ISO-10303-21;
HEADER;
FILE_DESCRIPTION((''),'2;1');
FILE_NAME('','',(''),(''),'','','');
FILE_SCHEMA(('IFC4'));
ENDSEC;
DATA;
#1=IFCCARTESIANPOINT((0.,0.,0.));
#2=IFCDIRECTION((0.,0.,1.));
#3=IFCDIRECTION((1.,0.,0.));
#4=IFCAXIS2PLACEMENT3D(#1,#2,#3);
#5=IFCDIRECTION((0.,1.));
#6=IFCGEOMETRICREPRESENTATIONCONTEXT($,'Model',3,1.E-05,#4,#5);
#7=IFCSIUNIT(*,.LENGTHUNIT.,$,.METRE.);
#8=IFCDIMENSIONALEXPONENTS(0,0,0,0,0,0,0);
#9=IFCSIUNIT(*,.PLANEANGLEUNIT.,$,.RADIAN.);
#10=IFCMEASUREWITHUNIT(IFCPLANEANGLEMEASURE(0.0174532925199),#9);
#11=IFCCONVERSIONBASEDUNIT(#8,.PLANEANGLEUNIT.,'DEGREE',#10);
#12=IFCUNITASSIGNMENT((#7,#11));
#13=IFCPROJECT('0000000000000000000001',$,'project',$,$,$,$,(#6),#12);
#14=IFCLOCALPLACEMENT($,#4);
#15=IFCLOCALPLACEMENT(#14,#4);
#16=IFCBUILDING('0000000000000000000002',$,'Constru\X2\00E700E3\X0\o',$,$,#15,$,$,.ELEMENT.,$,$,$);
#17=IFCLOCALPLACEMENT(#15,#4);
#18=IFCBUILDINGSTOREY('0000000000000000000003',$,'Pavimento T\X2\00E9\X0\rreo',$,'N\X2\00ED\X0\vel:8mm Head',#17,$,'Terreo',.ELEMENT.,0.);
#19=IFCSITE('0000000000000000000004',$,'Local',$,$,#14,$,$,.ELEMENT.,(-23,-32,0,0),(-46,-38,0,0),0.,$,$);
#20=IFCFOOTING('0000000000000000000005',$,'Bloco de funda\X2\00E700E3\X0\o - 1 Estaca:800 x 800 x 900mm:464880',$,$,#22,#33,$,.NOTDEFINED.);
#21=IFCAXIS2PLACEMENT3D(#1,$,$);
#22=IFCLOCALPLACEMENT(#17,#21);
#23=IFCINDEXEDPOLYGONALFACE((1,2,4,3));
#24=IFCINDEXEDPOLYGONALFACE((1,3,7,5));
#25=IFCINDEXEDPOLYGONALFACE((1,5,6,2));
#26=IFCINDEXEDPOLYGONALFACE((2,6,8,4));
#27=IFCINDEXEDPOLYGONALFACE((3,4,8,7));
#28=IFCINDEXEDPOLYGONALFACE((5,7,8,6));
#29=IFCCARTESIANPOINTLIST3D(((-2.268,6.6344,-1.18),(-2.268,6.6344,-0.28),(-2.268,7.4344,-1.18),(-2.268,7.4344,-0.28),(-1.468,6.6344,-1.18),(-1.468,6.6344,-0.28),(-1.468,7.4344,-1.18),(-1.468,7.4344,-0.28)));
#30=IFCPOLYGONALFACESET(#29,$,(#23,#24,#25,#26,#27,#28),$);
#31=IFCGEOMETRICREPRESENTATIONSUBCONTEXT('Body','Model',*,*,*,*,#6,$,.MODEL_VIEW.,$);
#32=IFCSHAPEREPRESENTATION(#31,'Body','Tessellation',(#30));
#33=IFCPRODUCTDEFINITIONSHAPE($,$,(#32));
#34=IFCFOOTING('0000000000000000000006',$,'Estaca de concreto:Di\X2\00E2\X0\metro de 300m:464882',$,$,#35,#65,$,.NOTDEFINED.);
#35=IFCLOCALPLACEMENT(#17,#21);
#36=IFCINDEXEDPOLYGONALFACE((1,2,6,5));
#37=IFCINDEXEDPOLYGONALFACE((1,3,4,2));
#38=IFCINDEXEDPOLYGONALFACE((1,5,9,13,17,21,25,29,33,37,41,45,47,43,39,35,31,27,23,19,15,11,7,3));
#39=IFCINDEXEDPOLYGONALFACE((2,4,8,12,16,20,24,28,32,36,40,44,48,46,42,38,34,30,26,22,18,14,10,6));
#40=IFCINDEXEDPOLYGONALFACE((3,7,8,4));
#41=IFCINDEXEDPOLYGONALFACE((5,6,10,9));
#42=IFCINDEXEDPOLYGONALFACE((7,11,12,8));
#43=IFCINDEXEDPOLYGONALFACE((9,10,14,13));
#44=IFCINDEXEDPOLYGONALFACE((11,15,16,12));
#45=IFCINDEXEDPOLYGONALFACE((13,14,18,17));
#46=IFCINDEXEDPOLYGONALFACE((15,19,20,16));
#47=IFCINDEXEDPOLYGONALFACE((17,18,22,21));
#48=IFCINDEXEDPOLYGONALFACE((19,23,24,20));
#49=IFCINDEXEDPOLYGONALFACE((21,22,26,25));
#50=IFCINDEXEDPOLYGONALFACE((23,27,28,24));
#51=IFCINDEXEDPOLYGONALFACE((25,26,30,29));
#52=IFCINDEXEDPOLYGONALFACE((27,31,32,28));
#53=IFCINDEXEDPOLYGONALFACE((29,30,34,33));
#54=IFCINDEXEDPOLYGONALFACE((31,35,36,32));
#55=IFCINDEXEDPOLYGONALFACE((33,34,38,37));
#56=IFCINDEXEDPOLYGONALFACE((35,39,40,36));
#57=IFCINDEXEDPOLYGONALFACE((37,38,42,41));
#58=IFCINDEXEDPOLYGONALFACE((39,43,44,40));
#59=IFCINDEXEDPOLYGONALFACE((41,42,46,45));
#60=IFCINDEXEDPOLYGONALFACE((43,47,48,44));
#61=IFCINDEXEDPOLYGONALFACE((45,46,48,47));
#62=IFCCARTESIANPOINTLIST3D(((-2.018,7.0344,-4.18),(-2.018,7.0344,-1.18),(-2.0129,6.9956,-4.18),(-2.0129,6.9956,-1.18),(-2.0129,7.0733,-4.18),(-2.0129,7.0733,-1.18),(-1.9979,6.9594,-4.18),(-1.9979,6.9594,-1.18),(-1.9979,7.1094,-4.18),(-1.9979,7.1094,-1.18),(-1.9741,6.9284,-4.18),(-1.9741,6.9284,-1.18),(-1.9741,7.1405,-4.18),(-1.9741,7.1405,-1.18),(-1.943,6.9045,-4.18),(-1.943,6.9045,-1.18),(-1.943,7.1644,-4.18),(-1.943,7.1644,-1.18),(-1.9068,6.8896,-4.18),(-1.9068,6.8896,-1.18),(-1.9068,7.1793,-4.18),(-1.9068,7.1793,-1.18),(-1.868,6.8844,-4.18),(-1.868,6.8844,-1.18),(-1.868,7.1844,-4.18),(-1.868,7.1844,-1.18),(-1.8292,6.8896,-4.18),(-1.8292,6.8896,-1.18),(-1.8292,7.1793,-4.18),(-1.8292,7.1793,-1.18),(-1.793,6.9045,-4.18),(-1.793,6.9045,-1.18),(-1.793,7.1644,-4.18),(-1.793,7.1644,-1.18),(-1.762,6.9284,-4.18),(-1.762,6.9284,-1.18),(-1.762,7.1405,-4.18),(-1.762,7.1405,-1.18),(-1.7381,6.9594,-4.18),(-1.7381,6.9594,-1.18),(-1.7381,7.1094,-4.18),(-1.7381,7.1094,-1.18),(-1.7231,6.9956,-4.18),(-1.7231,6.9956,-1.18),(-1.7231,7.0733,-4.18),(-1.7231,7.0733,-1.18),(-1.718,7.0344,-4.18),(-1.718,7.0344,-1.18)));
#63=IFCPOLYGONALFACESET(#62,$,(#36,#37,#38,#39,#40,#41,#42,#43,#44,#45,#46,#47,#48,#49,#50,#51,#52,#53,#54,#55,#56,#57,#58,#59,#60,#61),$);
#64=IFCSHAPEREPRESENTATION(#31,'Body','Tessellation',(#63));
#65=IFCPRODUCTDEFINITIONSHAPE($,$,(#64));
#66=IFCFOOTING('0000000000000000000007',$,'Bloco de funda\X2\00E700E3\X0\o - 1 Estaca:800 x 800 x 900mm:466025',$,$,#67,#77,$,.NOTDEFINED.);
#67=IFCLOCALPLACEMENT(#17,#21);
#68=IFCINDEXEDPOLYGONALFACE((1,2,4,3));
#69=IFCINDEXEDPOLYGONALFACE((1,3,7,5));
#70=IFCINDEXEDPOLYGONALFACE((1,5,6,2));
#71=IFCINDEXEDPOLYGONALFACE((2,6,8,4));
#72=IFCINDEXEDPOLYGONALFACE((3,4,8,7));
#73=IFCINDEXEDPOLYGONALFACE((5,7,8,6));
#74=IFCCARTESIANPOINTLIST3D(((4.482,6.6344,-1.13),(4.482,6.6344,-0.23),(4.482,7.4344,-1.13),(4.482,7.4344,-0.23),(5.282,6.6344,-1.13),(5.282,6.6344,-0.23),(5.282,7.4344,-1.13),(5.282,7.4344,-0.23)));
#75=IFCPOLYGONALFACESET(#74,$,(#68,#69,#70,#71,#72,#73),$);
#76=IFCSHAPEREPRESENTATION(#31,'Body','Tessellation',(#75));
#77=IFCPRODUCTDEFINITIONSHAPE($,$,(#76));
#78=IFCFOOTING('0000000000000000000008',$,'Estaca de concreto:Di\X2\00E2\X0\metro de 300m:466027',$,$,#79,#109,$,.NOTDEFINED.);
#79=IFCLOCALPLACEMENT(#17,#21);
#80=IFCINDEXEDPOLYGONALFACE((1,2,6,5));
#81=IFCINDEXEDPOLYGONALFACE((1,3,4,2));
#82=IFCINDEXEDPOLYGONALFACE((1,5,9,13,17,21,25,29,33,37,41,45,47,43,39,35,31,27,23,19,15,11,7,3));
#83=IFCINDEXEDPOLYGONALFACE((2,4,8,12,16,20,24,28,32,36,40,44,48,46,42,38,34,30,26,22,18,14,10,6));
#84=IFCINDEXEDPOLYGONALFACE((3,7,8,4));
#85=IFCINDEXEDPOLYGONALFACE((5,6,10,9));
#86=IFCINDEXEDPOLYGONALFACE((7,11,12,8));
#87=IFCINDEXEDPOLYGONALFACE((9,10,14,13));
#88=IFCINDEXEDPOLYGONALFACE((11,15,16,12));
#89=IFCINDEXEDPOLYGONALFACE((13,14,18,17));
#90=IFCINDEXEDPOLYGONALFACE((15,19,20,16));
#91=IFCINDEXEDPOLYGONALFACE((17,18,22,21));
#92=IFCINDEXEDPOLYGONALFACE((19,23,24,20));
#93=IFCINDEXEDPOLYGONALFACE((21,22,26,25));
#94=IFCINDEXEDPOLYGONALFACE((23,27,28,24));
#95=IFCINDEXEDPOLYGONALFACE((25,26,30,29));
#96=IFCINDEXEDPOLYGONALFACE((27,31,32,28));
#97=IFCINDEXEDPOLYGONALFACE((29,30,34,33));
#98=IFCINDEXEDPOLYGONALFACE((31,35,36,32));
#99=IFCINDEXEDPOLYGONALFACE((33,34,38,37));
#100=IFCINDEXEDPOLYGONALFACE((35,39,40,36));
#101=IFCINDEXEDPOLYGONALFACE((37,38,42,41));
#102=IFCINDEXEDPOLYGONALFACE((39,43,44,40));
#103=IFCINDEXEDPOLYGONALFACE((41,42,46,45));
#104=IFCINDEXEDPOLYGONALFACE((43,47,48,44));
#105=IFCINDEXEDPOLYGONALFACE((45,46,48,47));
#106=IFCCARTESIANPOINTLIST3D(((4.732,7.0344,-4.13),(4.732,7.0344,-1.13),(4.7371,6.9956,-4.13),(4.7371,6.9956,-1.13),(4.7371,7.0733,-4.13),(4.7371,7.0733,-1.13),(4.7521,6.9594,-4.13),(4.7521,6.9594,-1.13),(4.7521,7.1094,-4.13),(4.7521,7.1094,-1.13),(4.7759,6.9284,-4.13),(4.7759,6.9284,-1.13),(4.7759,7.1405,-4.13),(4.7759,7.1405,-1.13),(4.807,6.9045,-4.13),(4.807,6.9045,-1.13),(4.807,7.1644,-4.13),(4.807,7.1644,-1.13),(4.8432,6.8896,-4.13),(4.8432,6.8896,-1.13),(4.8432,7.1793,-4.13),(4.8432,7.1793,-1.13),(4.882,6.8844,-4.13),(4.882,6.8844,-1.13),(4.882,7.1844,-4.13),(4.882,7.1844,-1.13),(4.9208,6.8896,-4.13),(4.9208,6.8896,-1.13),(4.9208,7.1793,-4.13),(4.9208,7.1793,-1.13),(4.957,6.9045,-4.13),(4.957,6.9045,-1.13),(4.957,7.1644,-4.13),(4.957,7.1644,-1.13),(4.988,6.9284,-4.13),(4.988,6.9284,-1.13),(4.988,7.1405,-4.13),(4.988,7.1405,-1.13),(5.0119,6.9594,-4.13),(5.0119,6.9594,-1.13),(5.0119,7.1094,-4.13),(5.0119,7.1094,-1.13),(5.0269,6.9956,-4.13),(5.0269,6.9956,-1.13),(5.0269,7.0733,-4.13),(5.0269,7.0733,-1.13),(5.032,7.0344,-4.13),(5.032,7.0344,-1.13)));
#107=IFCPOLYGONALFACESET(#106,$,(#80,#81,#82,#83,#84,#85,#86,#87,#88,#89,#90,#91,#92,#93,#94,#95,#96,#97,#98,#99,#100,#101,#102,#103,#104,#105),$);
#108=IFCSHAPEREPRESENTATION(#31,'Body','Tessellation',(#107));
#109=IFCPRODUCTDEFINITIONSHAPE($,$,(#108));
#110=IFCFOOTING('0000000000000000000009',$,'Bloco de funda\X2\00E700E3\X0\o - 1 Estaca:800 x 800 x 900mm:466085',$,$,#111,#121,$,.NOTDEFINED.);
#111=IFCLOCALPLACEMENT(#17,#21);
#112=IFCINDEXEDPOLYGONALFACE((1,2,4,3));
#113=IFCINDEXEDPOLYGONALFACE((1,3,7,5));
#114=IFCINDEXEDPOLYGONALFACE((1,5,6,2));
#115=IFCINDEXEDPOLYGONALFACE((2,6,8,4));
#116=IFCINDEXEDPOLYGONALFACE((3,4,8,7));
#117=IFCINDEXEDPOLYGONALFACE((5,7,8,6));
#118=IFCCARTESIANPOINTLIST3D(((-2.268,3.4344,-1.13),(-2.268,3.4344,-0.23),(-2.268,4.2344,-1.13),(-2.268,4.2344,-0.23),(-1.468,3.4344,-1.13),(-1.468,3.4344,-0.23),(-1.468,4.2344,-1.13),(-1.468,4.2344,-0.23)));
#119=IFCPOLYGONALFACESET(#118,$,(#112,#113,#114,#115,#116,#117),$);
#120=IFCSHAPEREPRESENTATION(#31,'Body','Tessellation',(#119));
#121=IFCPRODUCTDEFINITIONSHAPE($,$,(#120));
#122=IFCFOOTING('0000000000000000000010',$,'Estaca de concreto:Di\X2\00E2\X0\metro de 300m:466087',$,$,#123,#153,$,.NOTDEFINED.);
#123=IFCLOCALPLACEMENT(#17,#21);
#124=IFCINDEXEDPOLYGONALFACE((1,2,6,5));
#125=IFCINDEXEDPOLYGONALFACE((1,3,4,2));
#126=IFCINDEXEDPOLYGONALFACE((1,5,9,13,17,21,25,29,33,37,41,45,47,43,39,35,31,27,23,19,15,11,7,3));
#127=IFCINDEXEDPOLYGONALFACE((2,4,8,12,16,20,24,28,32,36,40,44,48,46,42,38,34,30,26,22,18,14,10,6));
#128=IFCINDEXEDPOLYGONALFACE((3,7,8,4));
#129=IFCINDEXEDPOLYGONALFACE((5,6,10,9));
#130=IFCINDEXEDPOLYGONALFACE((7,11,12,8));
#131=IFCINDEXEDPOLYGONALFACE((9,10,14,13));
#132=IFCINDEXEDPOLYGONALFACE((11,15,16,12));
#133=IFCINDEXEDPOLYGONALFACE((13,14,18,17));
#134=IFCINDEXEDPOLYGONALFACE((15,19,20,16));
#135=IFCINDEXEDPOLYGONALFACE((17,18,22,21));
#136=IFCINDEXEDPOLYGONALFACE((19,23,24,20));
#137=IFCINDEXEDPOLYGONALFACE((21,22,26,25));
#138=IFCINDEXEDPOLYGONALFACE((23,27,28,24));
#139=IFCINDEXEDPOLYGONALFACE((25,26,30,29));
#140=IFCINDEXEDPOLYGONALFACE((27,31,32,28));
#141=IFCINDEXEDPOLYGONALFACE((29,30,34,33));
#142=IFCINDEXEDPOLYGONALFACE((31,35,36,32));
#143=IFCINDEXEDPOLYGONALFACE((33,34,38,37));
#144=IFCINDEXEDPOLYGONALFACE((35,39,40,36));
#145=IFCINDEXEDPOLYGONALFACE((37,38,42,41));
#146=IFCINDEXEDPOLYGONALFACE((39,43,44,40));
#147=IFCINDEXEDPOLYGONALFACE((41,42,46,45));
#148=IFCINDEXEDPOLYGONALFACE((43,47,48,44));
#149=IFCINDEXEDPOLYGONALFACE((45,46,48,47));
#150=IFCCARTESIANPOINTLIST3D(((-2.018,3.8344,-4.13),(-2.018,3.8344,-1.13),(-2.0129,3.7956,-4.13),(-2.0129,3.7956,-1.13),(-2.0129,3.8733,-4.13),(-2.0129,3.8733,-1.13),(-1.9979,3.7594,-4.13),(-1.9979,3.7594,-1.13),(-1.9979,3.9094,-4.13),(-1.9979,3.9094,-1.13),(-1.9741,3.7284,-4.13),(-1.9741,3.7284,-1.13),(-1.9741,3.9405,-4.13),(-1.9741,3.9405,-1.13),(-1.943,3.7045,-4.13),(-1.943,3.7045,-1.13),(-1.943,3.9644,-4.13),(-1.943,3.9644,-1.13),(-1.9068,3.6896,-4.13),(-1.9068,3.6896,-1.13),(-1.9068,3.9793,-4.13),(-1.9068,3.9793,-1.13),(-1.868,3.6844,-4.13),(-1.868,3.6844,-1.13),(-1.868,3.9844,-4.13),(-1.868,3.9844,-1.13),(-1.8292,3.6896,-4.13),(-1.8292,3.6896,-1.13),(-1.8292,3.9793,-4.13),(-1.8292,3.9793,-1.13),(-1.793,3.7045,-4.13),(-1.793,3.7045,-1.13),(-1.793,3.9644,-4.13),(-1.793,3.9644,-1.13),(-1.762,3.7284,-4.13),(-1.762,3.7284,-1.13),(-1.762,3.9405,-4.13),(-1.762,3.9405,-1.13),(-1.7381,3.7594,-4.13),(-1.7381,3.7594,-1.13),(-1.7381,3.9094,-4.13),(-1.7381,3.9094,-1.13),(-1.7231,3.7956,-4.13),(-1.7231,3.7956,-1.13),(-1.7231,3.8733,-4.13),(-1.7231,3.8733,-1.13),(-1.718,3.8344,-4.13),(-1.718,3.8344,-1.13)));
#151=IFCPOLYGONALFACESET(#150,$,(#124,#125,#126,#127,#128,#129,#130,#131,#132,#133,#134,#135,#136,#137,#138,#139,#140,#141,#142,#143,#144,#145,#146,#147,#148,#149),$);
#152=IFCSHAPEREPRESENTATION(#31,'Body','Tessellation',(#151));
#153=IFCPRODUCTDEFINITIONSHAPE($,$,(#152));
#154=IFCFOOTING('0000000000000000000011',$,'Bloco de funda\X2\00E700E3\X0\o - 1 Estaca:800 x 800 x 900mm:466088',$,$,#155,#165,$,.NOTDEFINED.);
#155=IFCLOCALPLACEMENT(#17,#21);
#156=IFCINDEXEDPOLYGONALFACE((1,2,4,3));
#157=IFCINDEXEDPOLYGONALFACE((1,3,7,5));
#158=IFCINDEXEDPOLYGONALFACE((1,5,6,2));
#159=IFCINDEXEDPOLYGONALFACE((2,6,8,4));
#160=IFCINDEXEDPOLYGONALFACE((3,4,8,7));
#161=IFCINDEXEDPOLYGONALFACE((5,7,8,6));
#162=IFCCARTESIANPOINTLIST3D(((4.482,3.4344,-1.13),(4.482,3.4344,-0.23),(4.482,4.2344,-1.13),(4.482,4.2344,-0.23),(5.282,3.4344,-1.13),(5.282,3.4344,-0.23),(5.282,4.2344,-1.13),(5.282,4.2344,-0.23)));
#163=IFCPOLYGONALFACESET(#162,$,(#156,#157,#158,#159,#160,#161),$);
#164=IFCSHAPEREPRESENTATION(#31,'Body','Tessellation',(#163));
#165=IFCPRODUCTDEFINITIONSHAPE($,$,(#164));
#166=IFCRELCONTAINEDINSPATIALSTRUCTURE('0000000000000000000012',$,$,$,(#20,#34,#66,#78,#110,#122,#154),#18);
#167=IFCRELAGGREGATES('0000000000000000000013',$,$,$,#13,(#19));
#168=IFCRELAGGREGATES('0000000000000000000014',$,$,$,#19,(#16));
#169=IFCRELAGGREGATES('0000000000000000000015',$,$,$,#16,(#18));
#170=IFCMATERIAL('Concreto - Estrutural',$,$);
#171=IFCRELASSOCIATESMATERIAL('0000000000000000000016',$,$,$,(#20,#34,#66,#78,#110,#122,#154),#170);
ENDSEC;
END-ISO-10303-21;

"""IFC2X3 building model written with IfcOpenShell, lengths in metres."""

from ifc_helpers import new_model, entity, si_unit, converted_unit, point, direction, frame, frame_2d, origin_with_axes, place, context, subcontext, project, spatial, polyline, circle_curve, parameter, trimmed, segment, composite_curve, outline, extrude, material, element, save


model = new_model("IFC2X3")

# Units and contexts
model_context = context("Model", 3, precision=1e-05, world=origin_with_axes(), true_north=direction((0.0, 1.0)))
body_context = subcontext(model_context, "Body", "Model", "MODEL_VIEW")
ifc_project = project(units=[si_unit("LENGTHUNIT", "METRE"), converted_unit("PLANEANGLEUNIT", "DEGREE", entity("IfcPlaneAngleMeasure", 0.0174532925199), si_unit("PLANEANGLEUNIT", "RADIAN"), dimensions=[0, 0, 0, 0, 0, 0, 0])], contexts=[model_context])

# Site, building, storey
site_placement = place(None, origin_with_axes())
site = spatial("IfcSite", under=ifc_project, at=site_placement, Name="Local", CompositionType="ELEMENT", RefLatitude=(-23, -32, 0, 0), RefLongitude=(-46, -38, 0, 0), RefElevation=0.0)
building_placement = place(site_placement, origin_with_axes())
building = spatial("IfcBuilding", under=site, at=building_placement, Name="Construção", CompositionType="ELEMENT")
storey_placement = place(building_placement, origin_with_axes())
storey = spatial("IfcBuildingStorey", under=building, at=storey_placement, Name="Pavimento Térreo", ObjectType="Nível:8mm Head", LongName="Terreo", CompositionType="ELEMENT", Elevation=0.0)

# Footings
ifc_material = material(Name="Concreto - Estrutural")
footing_1_placement = place(storey_placement, frame((-2.268, 7.4344, -0.28), z_axis=(0.0, 0.0, 1.0), x_axis=(1.0, 0.0, 0.0)))
element("IfcFooting", 1, at=footing_1_placement, inside=storey, material=ifc_material, Name="Bloco de fundação - 1 Estaca:800 x 800 x 900mm:464880", PredefinedType="NOTDEFINED", context=body_context, shape_type="SweptSolid", body=[
    extrude(outline(polyline([(0.0, 0.0), (0.0, -0.8), (0.8, -0.8), (0.8, 0.0), (0.0, 0.0)])), frame((0.0, 0.0, -0.9), z_axis=(0.0, 0.0, 1.0), x_axis=(1.0, 0.0, 0.0)), (0.0, 0.0, 1.0), 0.9),
])
footing_2_placement = place(storey_placement, frame((-1.718, 7.0344, -1.18), z_axis=(0.0, 0.0, 1.0), x_axis=(1.0, 0.0, 0.0)))
element("IfcFooting", 2, at=footing_2_placement, inside=storey, material=ifc_material, Name="Estaca de concreto:Diâmetro de 300m:464882", PredefinedType="NOTDEFINED", context=body_context, shape_type="SweptSolid", body=[
    extrude(outline(composite_curve([segment(trimmed(circle_curve(frame_2d((-0.15, 0.0), x_axis=(1.0, 0.0)), 0.15), [point((0.0, 0.0)), parameter(0.0)], [point((-0.15, 0.15)), parameter(90.0)], True, "CARTESIAN"), True, "CONTINUOUS"), segment(trimmed(circle_curve(frame_2d((-0.15, 0.0), x_axis=(0.0, 1.0)), 0.15), [point((-0.15, 0.15)), parameter(0.0)], [point((-0.3, 0.0)), parameter(90.0)], True, "CARTESIAN"), True, "CONTINUOUS"), segment(trimmed(circle_curve(frame_2d((-0.15, 0.0), x_axis=(-1.0, 0.0)), 0.15), [point((-0.3, 0.0)), parameter(0.0)], [point((-0.15, -0.15)), parameter(90.0)], True, "CARTESIAN"), True, "CONTINUOUS"), segment(trimmed(circle_curve(frame_2d((-0.15, 0.0), x_axis=(0.0, -1.0)), 0.15), [point((-0.15, -0.15)), parameter(0.0)], [point((0.0, 0.0)), parameter(90.0)], True, "CARTESIAN"), True, "CONTINUOUS")], self_intersect=False)), frame((0.0, 0.0, -3.0), z_axis=(0.0, 0.0, 1.0), x_axis=(1.0, 0.0, 0.0)), (0.0, 0.0, 1.0), 3.0),
])
footing_3_placement = place(storey_placement, frame((4.482, 7.4344, -0.23), z_axis=(0.0, 0.0, 1.0), x_axis=(1.0, 0.0, 0.0)))
element("IfcFooting", 3, at=footing_3_placement, inside=storey, material=ifc_material, Name="Bloco de fundação - 1 Estaca:800 x 800 x 900mm:466025", PredefinedType="NOTDEFINED", context=body_context, shape_type="SweptSolid", body=[
    extrude(outline(polyline([(0.0, 0.0), (0.0, -0.8), (0.8, -0.8), (0.8, 0.0), (0.0, 0.0)])), frame((0.0, 0.0, -0.9), z_axis=(0.0, 0.0, 1.0), x_axis=(1.0, 0.0, 0.0)), (0.0, 0.0, 1.0), 0.9),
])
footing_4_placement = place(storey_placement, frame((5.032, 7.0344, -1.13), z_axis=(0.0, 0.0, 1.0), x_axis=(1.0, 0.0, 0.0)))
element("IfcFooting", 4, at=footing_4_placement, inside=storey, material=ifc_material, Name="Estaca de concreto:Diâmetro de 300m:466027", PredefinedType="NOTDEFINED", context=body_context, shape_type="SweptSolid", body=[
    extrude(outline(composite_curve([segment(trimmed(circle_curve(frame_2d((-0.15, 0.0), x_axis=(1.0, 0.0)), 0.15), [point((0.0, 0.0)), parameter(0.0)], [point((-0.15, 0.15)), parameter(90.0)], True, "CARTESIAN"), True, "CONTINUOUS"), segment(trimmed(circle_curve(frame_2d((-0.15, 0.0), x_axis=(0.0, 1.0)), 0.15), [point((-0.15, 0.15)), parameter(0.0)], [point((-0.3, 0.0)), parameter(90.0)], True, "CARTESIAN"), True, "CONTINUOUS"), segment(trimmed(circle_curve(frame_2d((-0.15, 0.0), x_axis=(-1.0, 0.0)), 0.15), [point((-0.3, 0.0)), parameter(0.0)], [point((-0.15, -0.15)), parameter(90.0)], True, "CARTESIAN"), True, "CONTINUOUS"), segment(trimmed(circle_curve(frame_2d((-0.15, 0.0), x_axis=(0.0, -1.0)), 0.15), [point((-0.15, -0.15)), parameter(0.0)], [point((0.0, 0.0)), parameter(90.0)], True, "CARTESIAN"), True, "CONTINUOUS")], self_intersect=False)), frame((0.0, 0.0, -3.0), z_axis=(0.0, 0.0, 1.0), x_axis=(1.0, 0.0, 0.0)), (0.0, 0.0, 1.0), 3.0),
])
footing_5_placement = place(storey_placement, frame((-2.268, 4.2344, -0.23), z_axis=(0.0, 0.0, 1.0), x_axis=(1.0, 0.0, 0.0)))
element("IfcFooting", 5, at=footing_5_placement, inside=storey, material=ifc_material, Name="Bloco de fundação - 1 Estaca:800 x 800 x 900mm:466085", PredefinedType="NOTDEFINED", context=body_context, shape_type="SweptSolid", body=[
    extrude(outline(polyline([(0.0, 0.0), (0.0, -0.8), (0.8, -0.8), (0.8, 0.0), (0.0, 0.0)])), frame((0.0, 0.0, -0.9), z_axis=(0.0, 0.0, 1.0), x_axis=(1.0, 0.0, 0.0)), (0.0, 0.0, 1.0), 0.9),
])
footing_6_placement = place(storey_placement, frame((-1.718, 3.8344, -1.13), z_axis=(0.0, 0.0, 1.0), x_axis=(1.0, 0.0, 0.0)))
element("IfcFooting", 6, at=footing_6_placement, inside=storey, material=ifc_material, Name="Estaca de concreto:Diâmetro de 300m:466087", PredefinedType="NOTDEFINED", context=body_context, shape_type="SweptSolid", body=[
    extrude(outline(composite_curve([segment(trimmed(circle_curve(frame_2d((-0.15, 0.0), x_axis=(1.0, 0.0)), 0.15), [point((0.0, 0.0)), parameter(0.0)], [point((-0.15, 0.15)), parameter(90.0)], True, "CARTESIAN"), True, "CONTINUOUS"), segment(trimmed(circle_curve(frame_2d((-0.15, 0.0), x_axis=(0.0, 1.0)), 0.15), [point((-0.15, 0.15)), parameter(0.0)], [point((-0.3, 0.0)), parameter(90.0)], True, "CARTESIAN"), True, "CONTINUOUS"), segment(trimmed(circle_curve(frame_2d((-0.15, 0.0), x_axis=(-1.0, 0.0)), 0.15), [point((-0.3, 0.0)), parameter(0.0)], [point((-0.15, -0.15)), parameter(90.0)], True, "CARTESIAN"), True, "CONTINUOUS"), segment(trimmed(circle_curve(frame_2d((-0.15, 0.0), x_axis=(0.0, -1.0)), 0.15), [point((-0.15, -0.15)), parameter(0.0)], [point((0.0, 0.0)), parameter(90.0)], True, "CARTESIAN"), True, "CONTINUOUS")], self_intersect=False)), frame((0.0, 0.0, -3.0), z_axis=(0.0, 0.0, 1.0), x_axis=(1.0, 0.0, 0.0)), (0.0, 0.0, 1.0), 3.0),
])
footing_7_placement = place(storey_placement, frame((4.482, 4.2344, -0.23), z_axis=(0.0, 0.0, 1.0), x_axis=(1.0, 0.0, 0.0)))
element("IfcFooting", 7, at=footing_7_placement, inside=storey, material=ifc_material, Name="Bloco de fundação - 1 Estaca:800 x 800 x 900mm:466088", PredefinedType="NOTDEFINED", context=body_context, shape_type="SweptSolid", body=[
    extrude(outline(polyline([(0.0, 0.0), (0.0, -0.8), (0.8, -0.8), (0.8, 0.0), (0.0, 0.0)])), frame((0.0, 0.0, -0.9), z_axis=(0.0, 0.0, 1.0), x_axis=(1.0, 0.0, 0.0)), (0.0, 0.0, 1.0), 0.9),
])

save(model, "model.ifc")
